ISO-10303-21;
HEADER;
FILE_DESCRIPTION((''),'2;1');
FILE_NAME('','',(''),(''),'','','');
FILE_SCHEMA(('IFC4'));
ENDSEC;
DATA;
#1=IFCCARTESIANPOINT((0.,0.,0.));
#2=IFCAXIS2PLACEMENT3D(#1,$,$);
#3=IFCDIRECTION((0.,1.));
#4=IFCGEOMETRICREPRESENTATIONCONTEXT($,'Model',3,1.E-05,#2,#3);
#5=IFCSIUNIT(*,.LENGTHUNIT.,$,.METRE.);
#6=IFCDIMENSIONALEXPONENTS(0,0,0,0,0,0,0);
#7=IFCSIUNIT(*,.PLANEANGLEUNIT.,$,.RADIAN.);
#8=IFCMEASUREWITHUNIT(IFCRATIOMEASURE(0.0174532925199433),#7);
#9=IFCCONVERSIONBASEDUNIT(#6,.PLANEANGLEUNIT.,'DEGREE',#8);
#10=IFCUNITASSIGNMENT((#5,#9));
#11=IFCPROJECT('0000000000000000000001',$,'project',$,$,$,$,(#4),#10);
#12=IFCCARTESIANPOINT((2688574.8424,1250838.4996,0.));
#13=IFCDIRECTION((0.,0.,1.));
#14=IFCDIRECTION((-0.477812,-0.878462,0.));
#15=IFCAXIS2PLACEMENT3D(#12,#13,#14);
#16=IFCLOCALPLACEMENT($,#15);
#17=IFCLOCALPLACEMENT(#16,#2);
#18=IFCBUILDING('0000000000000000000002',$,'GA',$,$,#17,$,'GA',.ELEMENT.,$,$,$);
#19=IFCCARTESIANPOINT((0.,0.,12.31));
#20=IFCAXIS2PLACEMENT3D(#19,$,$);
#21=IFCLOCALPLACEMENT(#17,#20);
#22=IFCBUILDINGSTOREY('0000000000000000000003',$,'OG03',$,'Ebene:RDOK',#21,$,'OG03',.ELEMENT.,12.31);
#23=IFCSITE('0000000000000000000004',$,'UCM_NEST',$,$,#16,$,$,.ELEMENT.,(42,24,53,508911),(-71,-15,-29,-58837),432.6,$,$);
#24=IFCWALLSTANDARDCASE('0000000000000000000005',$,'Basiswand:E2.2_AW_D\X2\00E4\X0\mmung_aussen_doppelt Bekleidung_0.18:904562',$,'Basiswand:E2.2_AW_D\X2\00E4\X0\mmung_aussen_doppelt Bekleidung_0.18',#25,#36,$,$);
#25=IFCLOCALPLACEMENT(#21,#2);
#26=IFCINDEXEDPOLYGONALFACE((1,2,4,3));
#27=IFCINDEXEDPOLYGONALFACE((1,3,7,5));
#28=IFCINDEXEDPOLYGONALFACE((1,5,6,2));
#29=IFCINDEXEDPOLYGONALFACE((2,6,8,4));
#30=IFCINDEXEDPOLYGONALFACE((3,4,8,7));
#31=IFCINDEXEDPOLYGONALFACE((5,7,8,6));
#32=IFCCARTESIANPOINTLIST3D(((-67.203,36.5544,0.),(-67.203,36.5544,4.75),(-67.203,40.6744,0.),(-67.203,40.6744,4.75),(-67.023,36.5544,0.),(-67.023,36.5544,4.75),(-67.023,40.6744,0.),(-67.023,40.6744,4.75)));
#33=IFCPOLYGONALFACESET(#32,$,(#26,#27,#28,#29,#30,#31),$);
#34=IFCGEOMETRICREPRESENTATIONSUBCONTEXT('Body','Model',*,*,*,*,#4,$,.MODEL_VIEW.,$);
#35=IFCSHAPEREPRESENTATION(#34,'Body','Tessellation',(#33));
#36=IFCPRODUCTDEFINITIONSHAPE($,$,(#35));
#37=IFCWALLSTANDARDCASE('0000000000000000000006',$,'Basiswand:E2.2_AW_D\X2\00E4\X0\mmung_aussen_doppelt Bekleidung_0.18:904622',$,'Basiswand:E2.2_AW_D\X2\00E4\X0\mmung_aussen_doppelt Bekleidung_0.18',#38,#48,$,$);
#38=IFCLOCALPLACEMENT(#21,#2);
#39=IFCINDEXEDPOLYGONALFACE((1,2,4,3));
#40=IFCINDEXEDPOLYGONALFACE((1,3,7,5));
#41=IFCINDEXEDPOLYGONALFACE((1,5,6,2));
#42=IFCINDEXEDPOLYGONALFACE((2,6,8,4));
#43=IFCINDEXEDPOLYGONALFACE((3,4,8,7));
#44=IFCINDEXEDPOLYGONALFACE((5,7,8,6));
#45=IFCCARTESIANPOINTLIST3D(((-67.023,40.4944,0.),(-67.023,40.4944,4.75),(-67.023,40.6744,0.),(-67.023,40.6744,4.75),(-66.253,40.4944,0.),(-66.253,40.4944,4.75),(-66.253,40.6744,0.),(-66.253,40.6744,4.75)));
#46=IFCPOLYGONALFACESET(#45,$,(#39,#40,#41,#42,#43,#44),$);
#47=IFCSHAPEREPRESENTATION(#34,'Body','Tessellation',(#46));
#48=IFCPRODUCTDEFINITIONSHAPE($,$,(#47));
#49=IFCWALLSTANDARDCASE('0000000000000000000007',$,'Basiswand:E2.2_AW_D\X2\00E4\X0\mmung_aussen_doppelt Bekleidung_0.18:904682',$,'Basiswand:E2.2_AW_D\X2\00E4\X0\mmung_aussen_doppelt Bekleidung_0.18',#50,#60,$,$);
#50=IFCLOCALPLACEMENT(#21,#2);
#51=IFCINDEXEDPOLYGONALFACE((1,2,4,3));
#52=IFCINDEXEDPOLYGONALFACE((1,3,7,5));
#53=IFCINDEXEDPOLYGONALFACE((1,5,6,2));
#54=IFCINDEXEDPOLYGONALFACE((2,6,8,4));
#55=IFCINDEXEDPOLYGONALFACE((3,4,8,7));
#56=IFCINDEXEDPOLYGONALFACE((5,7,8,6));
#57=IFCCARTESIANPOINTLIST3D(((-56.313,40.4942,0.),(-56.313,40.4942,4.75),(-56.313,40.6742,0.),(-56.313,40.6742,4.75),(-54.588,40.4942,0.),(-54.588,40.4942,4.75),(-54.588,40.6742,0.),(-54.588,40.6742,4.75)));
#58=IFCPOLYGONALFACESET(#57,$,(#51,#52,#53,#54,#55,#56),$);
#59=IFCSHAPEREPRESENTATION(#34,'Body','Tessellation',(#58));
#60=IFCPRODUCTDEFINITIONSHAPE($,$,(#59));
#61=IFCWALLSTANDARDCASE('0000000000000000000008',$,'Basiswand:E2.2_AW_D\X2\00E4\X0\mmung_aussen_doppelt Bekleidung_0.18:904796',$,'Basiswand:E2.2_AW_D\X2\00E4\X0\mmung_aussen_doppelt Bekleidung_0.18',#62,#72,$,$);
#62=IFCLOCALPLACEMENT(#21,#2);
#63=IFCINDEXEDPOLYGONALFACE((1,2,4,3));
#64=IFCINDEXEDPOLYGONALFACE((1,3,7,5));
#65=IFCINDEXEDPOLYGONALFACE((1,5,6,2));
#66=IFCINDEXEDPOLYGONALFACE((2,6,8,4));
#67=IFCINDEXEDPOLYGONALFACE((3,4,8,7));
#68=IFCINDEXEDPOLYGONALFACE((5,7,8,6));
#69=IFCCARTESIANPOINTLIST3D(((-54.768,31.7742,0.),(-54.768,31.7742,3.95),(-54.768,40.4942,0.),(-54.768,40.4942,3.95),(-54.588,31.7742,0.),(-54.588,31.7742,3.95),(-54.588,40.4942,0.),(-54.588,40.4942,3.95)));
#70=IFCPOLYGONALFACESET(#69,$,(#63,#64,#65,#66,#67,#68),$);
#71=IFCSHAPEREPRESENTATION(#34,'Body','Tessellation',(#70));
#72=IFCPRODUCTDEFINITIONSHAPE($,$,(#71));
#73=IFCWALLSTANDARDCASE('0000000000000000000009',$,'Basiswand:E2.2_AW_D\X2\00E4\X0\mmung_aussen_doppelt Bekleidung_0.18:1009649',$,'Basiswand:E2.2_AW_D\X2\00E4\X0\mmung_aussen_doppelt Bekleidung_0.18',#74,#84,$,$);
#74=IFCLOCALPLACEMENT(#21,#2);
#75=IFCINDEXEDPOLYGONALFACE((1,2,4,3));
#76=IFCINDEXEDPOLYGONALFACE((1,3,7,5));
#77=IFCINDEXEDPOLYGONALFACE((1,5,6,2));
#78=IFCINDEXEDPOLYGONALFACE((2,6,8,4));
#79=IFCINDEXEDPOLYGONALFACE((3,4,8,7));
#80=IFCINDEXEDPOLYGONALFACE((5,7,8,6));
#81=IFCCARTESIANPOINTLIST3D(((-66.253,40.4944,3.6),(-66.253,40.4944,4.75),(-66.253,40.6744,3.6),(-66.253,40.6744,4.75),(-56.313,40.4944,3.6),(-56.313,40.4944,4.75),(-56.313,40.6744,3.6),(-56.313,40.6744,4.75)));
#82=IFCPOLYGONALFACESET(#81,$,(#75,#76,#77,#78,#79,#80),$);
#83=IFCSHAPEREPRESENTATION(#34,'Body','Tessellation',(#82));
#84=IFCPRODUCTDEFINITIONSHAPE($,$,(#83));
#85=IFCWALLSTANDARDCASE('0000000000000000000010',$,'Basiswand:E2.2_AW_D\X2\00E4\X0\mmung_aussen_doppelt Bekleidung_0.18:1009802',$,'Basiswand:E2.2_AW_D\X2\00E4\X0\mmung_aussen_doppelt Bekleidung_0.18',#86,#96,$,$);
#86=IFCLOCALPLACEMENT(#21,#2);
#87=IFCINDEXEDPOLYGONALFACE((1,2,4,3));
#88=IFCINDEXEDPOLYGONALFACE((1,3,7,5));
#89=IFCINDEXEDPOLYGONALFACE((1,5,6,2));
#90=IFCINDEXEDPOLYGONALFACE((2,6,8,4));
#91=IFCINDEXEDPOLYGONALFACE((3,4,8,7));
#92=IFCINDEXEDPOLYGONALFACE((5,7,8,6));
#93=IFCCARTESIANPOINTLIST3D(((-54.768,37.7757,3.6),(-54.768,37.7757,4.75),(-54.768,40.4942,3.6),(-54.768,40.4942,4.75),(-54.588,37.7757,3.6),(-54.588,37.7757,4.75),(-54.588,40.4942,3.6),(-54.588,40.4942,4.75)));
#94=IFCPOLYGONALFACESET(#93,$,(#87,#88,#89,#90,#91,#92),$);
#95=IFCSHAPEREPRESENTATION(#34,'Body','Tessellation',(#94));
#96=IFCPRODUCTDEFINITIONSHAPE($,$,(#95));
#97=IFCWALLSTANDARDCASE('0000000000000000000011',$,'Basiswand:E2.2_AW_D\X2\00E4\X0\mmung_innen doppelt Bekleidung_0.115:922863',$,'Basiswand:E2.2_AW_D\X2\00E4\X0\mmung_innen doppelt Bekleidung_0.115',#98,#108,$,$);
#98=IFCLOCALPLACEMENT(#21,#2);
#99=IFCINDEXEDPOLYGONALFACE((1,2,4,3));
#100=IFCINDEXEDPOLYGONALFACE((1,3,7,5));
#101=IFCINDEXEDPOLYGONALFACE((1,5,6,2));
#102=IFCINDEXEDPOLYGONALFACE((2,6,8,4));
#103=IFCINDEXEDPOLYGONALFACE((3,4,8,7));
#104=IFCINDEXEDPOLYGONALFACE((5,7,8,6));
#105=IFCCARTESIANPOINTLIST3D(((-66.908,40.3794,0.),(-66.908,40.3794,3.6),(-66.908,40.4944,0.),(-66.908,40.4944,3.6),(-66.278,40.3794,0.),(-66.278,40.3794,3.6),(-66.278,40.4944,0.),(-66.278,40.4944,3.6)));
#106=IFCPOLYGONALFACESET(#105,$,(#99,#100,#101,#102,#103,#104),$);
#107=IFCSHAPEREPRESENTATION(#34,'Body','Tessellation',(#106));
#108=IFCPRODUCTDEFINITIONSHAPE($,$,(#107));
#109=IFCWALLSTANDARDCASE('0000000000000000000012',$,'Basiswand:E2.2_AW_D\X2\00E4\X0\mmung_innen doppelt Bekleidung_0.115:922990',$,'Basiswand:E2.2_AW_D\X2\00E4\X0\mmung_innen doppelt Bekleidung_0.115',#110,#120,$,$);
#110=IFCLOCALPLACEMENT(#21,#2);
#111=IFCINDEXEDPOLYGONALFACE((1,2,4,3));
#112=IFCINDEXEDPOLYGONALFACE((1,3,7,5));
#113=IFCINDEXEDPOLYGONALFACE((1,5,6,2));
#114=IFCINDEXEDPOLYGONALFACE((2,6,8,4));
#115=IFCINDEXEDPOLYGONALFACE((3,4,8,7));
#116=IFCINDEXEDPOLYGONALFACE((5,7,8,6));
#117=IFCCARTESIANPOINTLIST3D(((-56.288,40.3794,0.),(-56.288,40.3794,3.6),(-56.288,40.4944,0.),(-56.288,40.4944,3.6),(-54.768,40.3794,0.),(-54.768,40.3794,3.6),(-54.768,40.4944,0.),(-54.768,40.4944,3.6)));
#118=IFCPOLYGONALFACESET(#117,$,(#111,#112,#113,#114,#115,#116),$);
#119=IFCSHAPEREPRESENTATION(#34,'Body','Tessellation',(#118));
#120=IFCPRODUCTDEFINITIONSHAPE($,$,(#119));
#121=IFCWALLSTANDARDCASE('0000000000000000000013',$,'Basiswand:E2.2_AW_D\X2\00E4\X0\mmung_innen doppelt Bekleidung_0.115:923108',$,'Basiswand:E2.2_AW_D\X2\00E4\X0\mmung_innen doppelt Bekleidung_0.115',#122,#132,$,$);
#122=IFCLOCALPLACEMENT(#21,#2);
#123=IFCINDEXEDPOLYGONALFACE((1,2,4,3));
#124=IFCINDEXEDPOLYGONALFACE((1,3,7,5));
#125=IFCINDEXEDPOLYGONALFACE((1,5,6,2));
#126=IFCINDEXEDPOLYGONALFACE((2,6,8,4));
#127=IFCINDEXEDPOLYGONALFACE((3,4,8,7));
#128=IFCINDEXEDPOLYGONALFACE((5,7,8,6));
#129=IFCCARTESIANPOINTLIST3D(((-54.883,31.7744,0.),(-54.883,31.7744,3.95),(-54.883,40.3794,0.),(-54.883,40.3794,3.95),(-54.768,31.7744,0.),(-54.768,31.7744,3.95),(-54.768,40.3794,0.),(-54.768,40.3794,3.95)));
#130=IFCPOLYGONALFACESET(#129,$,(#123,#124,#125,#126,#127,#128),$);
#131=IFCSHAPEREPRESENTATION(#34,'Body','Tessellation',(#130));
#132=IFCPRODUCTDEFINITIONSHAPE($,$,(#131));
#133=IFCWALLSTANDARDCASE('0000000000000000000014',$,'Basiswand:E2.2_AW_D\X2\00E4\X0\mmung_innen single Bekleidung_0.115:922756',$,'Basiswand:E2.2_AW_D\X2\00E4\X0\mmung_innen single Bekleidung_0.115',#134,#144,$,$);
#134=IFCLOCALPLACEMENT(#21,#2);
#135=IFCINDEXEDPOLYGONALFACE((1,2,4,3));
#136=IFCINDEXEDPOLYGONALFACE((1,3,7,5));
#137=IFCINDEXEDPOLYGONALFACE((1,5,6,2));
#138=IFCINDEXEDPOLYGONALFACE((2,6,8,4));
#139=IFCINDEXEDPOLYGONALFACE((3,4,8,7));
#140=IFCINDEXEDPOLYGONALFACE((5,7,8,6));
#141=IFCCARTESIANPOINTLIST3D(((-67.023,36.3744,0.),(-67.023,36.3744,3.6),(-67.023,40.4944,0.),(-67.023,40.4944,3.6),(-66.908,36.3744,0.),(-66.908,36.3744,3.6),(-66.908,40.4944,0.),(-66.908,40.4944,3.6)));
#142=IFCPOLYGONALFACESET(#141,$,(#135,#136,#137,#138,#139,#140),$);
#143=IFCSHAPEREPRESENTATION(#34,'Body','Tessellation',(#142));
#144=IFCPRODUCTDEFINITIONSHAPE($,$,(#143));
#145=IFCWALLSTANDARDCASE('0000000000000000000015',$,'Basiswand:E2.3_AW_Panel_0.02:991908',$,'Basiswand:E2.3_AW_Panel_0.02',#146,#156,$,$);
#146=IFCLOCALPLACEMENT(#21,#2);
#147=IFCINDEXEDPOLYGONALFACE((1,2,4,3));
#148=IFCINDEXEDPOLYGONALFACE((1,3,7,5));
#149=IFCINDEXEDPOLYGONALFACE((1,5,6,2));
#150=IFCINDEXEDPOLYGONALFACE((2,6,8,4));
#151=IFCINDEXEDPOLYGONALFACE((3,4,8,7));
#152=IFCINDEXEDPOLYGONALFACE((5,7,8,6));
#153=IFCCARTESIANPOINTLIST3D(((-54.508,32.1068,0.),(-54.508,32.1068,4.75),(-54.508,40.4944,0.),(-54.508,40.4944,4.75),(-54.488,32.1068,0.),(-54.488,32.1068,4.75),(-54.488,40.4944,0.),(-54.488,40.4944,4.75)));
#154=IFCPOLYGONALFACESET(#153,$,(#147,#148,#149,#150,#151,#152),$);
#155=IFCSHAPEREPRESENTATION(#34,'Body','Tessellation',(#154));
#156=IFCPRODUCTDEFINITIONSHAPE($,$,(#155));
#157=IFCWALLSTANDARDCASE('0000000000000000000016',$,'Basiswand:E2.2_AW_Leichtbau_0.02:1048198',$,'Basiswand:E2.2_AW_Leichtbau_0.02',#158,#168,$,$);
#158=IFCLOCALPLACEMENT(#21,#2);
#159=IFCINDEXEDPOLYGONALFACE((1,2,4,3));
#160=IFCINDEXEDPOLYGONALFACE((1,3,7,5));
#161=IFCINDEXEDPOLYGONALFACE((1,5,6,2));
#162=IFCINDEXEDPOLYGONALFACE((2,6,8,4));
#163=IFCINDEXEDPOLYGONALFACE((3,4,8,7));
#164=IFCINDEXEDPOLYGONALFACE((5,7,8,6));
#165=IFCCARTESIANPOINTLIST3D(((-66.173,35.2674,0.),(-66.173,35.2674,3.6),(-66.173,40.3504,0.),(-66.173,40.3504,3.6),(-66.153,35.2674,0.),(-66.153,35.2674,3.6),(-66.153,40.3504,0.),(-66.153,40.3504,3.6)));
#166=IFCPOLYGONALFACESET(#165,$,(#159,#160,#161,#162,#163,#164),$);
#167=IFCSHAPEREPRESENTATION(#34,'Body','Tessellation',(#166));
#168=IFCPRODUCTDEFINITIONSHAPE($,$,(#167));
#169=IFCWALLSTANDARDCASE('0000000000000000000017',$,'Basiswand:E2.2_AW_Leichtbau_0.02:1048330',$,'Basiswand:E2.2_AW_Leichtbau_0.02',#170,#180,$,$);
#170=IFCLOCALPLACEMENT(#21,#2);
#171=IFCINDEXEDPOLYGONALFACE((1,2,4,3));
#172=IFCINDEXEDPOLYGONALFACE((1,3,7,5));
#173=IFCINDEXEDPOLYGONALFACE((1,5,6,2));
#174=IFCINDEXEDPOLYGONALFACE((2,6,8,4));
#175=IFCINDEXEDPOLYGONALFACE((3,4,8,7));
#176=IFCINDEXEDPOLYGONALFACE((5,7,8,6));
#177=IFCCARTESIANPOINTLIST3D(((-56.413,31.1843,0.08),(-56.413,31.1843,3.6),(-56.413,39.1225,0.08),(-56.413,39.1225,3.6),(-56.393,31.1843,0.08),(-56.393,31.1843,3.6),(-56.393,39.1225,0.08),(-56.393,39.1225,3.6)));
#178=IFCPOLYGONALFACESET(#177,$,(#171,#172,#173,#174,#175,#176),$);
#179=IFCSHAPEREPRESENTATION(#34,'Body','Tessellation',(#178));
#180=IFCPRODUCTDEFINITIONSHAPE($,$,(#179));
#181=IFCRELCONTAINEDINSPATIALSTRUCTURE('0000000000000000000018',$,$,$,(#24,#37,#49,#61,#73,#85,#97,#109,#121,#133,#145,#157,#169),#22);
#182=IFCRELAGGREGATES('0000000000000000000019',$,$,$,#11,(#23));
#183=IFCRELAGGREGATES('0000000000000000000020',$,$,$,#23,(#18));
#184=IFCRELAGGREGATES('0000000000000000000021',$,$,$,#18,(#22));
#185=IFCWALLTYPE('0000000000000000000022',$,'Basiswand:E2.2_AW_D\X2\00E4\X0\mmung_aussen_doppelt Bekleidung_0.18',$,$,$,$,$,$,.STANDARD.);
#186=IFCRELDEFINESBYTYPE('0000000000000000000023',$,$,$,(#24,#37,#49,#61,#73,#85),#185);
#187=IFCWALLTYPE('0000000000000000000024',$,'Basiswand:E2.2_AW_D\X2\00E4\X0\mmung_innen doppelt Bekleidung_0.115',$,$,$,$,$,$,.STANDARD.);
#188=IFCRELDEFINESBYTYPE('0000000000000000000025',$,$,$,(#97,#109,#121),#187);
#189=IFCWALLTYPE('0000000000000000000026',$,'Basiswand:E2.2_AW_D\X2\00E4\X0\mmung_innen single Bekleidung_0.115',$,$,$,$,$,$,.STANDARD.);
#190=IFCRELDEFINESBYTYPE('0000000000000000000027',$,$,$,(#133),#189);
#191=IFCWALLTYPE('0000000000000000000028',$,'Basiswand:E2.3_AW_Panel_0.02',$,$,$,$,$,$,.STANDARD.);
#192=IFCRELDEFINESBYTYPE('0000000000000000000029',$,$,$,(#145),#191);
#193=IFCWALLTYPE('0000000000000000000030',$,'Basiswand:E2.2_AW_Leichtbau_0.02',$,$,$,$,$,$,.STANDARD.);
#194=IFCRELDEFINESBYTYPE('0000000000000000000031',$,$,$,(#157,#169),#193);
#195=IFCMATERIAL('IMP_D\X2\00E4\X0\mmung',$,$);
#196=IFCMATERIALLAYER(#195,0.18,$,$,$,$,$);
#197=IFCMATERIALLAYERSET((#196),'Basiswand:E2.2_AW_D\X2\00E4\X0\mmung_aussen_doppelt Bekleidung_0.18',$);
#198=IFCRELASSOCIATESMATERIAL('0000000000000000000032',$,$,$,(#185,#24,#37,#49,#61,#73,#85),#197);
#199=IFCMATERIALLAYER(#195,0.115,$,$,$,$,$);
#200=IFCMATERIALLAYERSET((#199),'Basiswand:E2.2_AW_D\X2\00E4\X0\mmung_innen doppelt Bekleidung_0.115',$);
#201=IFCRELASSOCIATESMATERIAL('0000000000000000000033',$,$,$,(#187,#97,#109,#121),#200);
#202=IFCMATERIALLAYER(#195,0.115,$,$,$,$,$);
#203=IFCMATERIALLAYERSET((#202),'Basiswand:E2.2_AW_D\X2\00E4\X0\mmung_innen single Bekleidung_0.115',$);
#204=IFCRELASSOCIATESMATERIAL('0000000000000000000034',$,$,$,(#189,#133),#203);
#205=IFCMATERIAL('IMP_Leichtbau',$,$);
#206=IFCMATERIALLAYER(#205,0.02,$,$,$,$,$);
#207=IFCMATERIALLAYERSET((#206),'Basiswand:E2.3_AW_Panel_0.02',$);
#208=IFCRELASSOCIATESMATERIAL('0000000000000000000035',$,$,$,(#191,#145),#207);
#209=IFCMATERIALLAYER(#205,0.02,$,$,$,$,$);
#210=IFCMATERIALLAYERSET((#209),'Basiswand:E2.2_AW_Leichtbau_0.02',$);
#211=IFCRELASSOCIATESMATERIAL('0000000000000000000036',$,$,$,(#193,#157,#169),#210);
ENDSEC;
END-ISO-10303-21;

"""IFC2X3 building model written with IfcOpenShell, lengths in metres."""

from ifc_helpers import new_model, entity, si_unit, converted_unit, direction, frame, frame_2d, origin, place, context, subcontext, project, spatial, polyline, rectangle, extrude, clip, bounded_halfspace, material, layer, layer_set, layer_usage, type_object, element, save


model = new_model("IFC2X3")

# Units and contexts
model_context = context("Model", 3, precision=1e-05, world=origin(), true_north=direction((0.0, 1.0)))
body_context = subcontext(model_context, "Body", "Model", "MODEL_VIEW")
ifc_project = project(units=[si_unit("LENGTHUNIT", "METRE"), converted_unit("PLANEANGLEUNIT", "DEGREE", entity("IfcRatioMeasure", 0.0174532925199433), si_unit("PLANEANGLEUNIT", "RADIAN"), dimensions=[0, 0, 0, 0, 0, 0, 0])], contexts=[model_context])

# Site, building, storey
site_placement = place(None, frame((2688574.8424, 1250838.4996, 0.0), z_axis=(0.0, 0.0, 1.0), x_axis=(-0.477812, -0.878462, 0.0)))
site = spatial("IfcSite", under=ifc_project, at=site_placement, Name="UCM_NEST", CompositionType="ELEMENT", RefLatitude=(42, 24, 53, 508911), RefLongitude=(-71, -15, -29, -58837), RefElevation=432.6)
building_placement = place(site_placement, origin())
building = spatial("IfcBuilding", under=site, at=building_placement, Name="GA", LongName="GA", CompositionType="ELEMENT")
storey_placement = place(building_placement, frame((0.0, 0.0, 12.31)))
storey = spatial("IfcBuildingStorey", under=building, at=storey_placement, Name="OG03", ObjectType="Ebene:RDOK", LongName="OG03", CompositionType="ELEMENT", Elevation=12.31)

# Walls
ifc_material_1 = material(Name="IMP_Dämmung")
ifc_layer_1 = layer(ifc_material_1, 0.18)
ifc_layer_set_1 = layer_set([ifc_layer_1], Name="Basiswand:E2.2_AW_Dämmung_aussen_doppelt Bekleidung_0.18")
ifc_layer_usage_1 = layer_usage(ifc_layer_set_1, "AXIS2", "NEGATIVE", 0.09)
wall_type_1 = type_object("IfcWallType", Name="Basiswand:E2.2_AW_Dämmung_aussen_doppelt Bekleidung_0.18", PredefinedType="STANDARD", material=ifc_layer_set_1)
wall_1_placement = place(storey_placement, frame((-67.113, 36.5544, 0.0), z_axis=(0.0, 0.0, 1.0), x_axis=(0.0, 1.0, 0.0)))
element("IfcWallStandardCase", 1, at=wall_1_placement, inside=storey, type_object=wall_type_1, material=ifc_layer_usage_1, Name="Basiswand:E2.2_AW_Dämmung_aussen_doppelt Bekleidung_0.18:904562", ObjectType="Basiswand:E2.2_AW_Dämmung_aussen_doppelt Bekleidung_0.18", context=body_context, shape_type="SweptSolid", body=[
    extrude(rectangle(XDim=4.12, YDim=0.18, at=frame_2d((2.06, 0.0), x_axis=(-1.0, 0.0))), origin(), (0.0, 0.0, 1.0), 4.75),
])
ifc_layer_usage_2 = layer_usage(ifc_layer_set_1, "AXIS2", "NEGATIVE", 0.09)
wall_2_placement = place(storey_placement, frame((-67.023, 40.5844, 0.0)))
element("IfcWallStandardCase", 2, at=wall_2_placement, inside=storey, type_object=wall_type_1, material=ifc_layer_usage_2, Name="Basiswand:E2.2_AW_Dämmung_aussen_doppelt Bekleidung_0.18:904622", ObjectType="Basiswand:E2.2_AW_Dämmung_aussen_doppelt Bekleidung_0.18", context=body_context, shape_type="SweptSolid", body=[
    extrude(rectangle(XDim=0.77, YDim=0.18, at=frame_2d((0.385, 0.0), x_axis=(-1.0, 0.0))), origin(), (0.0, 0.0, 1.0), 4.75),
])
ifc_layer_usage_3 = layer_usage(ifc_layer_set_1, "AXIS2", "NEGATIVE", 0.09)
wall_3_placement = place(storey_placement, frame((-56.313, 40.5842, 0.0)))
element("IfcWallStandardCase", 3, at=wall_3_placement, inside=storey, type_object=wall_type_1, material=ifc_layer_usage_3, Name="Basiswand:E2.2_AW_Dämmung_aussen_doppelt Bekleidung_0.18:904682", ObjectType="Basiswand:E2.2_AW_Dämmung_aussen_doppelt Bekleidung_0.18", context=body_context, shape_type="SweptSolid", body=[
    extrude(rectangle(XDim=1.725, YDim=0.18, at=frame_2d((0.8625, 0.0), x_axis=(-1.0, 0.0))), origin(), (0.0, 0.0, 1.0), 4.75),
])
ifc_layer_usage_4 = layer_usage(ifc_layer_set_1, "AXIS2", "NEGATIVE", 0.09)
wall_4_placement = place(storey_placement, frame((-54.678, 40.4942, 0.0), z_axis=(0.0, 0.0, 1.0), x_axis=(0.0, -1.0, 0.0)))
element("IfcWallStandardCase", 4, at=wall_4_placement, inside=storey, type_object=wall_type_1, material=ifc_layer_usage_4, Name="Basiswand:E2.2_AW_Dämmung_aussen_doppelt Bekleidung_0.18:904796", ObjectType="Basiswand:E2.2_AW_Dämmung_aussen_doppelt Bekleidung_0.18", context=body_context, shape_type="SweptSolid", body=[
    extrude(rectangle(XDim=8.72, YDim=0.18, at=frame_2d((4.36, 0.0), x_axis=(-1.0, 0.0))), origin(), (0.0, 0.0, 1.0), 3.95),
])
ifc_layer_usage_5 = layer_usage(ifc_layer_set_1, "AXIS2", "NEGATIVE", 0.09)
wall_5_placement = place(storey_placement, frame((-66.253, 40.5844, 3.6)))
element("IfcWallStandardCase", 5, at=wall_5_placement, inside=storey, type_object=wall_type_1, material=ifc_layer_usage_5, Name="Basiswand:E2.2_AW_Dämmung_aussen_doppelt Bekleidung_0.18:1009649", ObjectType="Basiswand:E2.2_AW_Dämmung_aussen_doppelt Bekleidung_0.18", context=body_context, shape_type="SweptSolid", body=[
    extrude(rectangle(XDim=9.94, YDim=0.18, at=frame_2d((4.97, 0.0), x_axis=(-1.0, 0.0))), origin(), (0.0, 0.0, 1.0), 1.15),
])
ifc_layer_usage_6 = layer_usage(ifc_layer_set_1, "AXIS2", "NEGATIVE", 0.09)
wall_6_placement = place(storey_placement, frame((-54.678, 37.7757, 3.6), z_axis=(0.0, 0.0, 1.0), x_axis=(0.0, 1.0, 0.0)))
element("IfcWallStandardCase", 6, at=wall_6_placement, inside=storey, type_object=wall_type_1, material=ifc_layer_usage_6, Name="Basiswand:E2.2_AW_Dämmung_aussen_doppelt Bekleidung_0.18:1009802", ObjectType="Basiswand:E2.2_AW_Dämmung_aussen_doppelt Bekleidung_0.18", context=body_context, shape_type="SweptSolid", body=[
    extrude(rectangle(XDim=2.7185, YDim=0.18, at=frame_2d((1.3592, 0.0), x_axis=(-1.0, 0.0))), origin(), (0.0, 0.0, 1.0), 1.15),
])
ifc_layer_2 = layer(ifc_material_1, 0.115)
ifc_layer_set_2 = layer_set([ifc_layer_2], Name="Basiswand:E2.2_AW_Dämmung_innen doppelt Bekleidung_0.115")
ifc_layer_usage_7 = layer_usage(ifc_layer_set_2, "AXIS2", "NEGATIVE", 0.0575)
wall_type_2 = type_object("IfcWallType", Name="Basiswand:E2.2_AW_Dämmung_innen doppelt Bekleidung_0.115", PredefinedType="STANDARD", material=ifc_layer_set_2)
wall_7_placement = place(storey_placement, frame((-66.908, 40.4369, 0.0)))
element("IfcWallStandardCase", 7, at=wall_7_placement, inside=storey, type_object=wall_type_2, material=ifc_layer_usage_7, Name="Basiswand:E2.2_AW_Dämmung_innen doppelt Bekleidung_0.115:922863", ObjectType="Basiswand:E2.2_AW_Dämmung_innen doppelt Bekleidung_0.115", context=body_context, shape_type="SweptSolid", body=[
    extrude(rectangle(XDim=0.63, YDim=0.115, at=frame_2d((0.315, 0.0), x_axis=(-1.0, 0.0))), origin(), (0.0, 0.0, 1.0), 3.6),
])
ifc_layer_usage_8 = layer_usage(ifc_layer_set_2, "AXIS2", "NEGATIVE", 0.0575)
wall_8_placement = place(storey_placement, frame((-56.288, 40.4369, 0.0)))
element("IfcWallStandardCase", 8, at=wall_8_placement, inside=storey, type_object=wall_type_2, material=ifc_layer_usage_8, Name="Basiswand:E2.2_AW_Dämmung_innen doppelt Bekleidung_0.115:922990", ObjectType="Basiswand:E2.2_AW_Dämmung_innen doppelt Bekleidung_0.115", context=body_context, shape_type="SweptSolid", body=[
    extrude(rectangle(XDim=1.52, YDim=0.115, at=frame_2d((0.76, 0.0), x_axis=(-1.0, 0.0))), origin(), (0.0, 0.0, 1.0), 3.6),
])
ifc_layer_usage_9 = layer_usage(ifc_layer_set_2, "AXIS2", "NEGATIVE", 0.0575)
wall_9_placement = place(storey_placement, frame((-54.8255, 40.3794, 0.0), z_axis=(0.0, 0.0, 1.0), x_axis=(0.0, -1.0, 0.0)))
element("IfcWallStandardCase", 9, at=wall_9_placement, inside=storey, type_object=wall_type_2, material=ifc_layer_usage_9, Name="Basiswand:E2.2_AW_Dämmung_innen doppelt Bekleidung_0.115:923108", ObjectType="Basiswand:E2.2_AW_Dämmung_innen doppelt Bekleidung_0.115", context=body_context, shape_type="SweptSolid", body=[
    extrude(rectangle(XDim=8.605, YDim=0.115, at=frame_2d((4.3025, 0.0), x_axis=(-1.0, 0.0))), origin(), (0.0, 0.0, 1.0), 3.95),
])
ifc_layer_3 = layer(ifc_material_1, 0.115)
ifc_layer_set_3 = layer_set([ifc_layer_3], Name="Basiswand:E2.2_AW_Dämmung_innen single Bekleidung_0.115")
ifc_layer_usage_10 = layer_usage(ifc_layer_set_3, "AXIS2", "NEGATIVE", 0.0575)
wall_type_3 = type_object("IfcWallType", Name="Basiswand:E2.2_AW_Dämmung_innen single Bekleidung_0.115", PredefinedType="STANDARD", material=ifc_layer_set_3)
wall_10_placement = place(storey_placement, frame((-66.9655, 36.3744, 0.0), z_axis=(0.0, 0.0, 1.0), x_axis=(0.0, 1.0, 0.0)))
element("IfcWallStandardCase", 10, at=wall_10_placement, inside=storey, type_object=wall_type_3, material=ifc_layer_usage_10, Name="Basiswand:E2.2_AW_Dämmung_innen single Bekleidung_0.115:922756", ObjectType="Basiswand:E2.2_AW_Dämmung_innen single Bekleidung_0.115", context=body_context, shape_type="SweptSolid", body=[
    extrude(rectangle(XDim=4.12, YDim=0.115, at=frame_2d((2.06, 0.0), x_axis=(-1.0, 0.0))), origin(), (0.0, 0.0, 1.0), 3.6),
])

# Walls
ifc_material_2 = material(Name="IMP_Leichtbau")
ifc_layer_4 = layer(ifc_material_2, 0.02)
ifc_layer_set_4 = layer_set([ifc_layer_4], Name="Basiswand:E2.3_AW_Panel_0.02")
ifc_layer_usage_11 = layer_usage(ifc_layer_set_4, "AXIS2", "NEGATIVE", 0.01)
wall_type_4 = type_object("IfcWallType", Name="Basiswand:E2.3_AW_Panel_0.02", PredefinedType="STANDARD", material=ifc_layer_set_4)
wall_11_placement = place(storey_placement, frame((-54.498, 40.4944, 0.0), z_axis=(0.0, 0.0, 1.0), x_axis=(0.0, -1.0, 0.0)))
element("IfcWallStandardCase", 11, at=wall_11_placement, inside=storey, type_object=wall_type_4, material=ifc_layer_usage_11, Name="Basiswand:E2.3_AW_Panel_0.02:991908", ObjectType="Basiswand:E2.3_AW_Panel_0.02", context=body_context, shape_type="SweptSolid", body=[
    extrude(rectangle(XDim=8.3877, YDim=0.02, at=frame_2d((4.1938, 0.0), x_axis=(-1.0, 0.0))), origin(), (0.0, 0.0, 1.0), 4.75),
])
ifc_layer_5 = layer(ifc_material_2, 0.02)
ifc_layer_set_5 = layer_set([ifc_layer_5], Name="Basiswand:E2.2_AW_Leichtbau_0.02")
ifc_layer_usage_12 = layer_usage(ifc_layer_set_5, "AXIS2", "NEGATIVE", 0.01)
wall_type_5 = type_object("IfcWallType", Name="Basiswand:E2.2_AW_Leichtbau_0.02", PredefinedType="STANDARD", material=ifc_layer_set_5)
wall_12_placement = place(storey_placement, frame((-66.163, 35.2674, 0.0), z_axis=(0.0, 0.0, 1.0), x_axis=(0.0, 1.0, 0.0)))
element("IfcWallStandardCase", 12, at=wall_12_placement, inside=storey, type_object=wall_type_5, material=ifc_layer_usage_12, Name="Basiswand:E2.2_AW_Leichtbau_0.02:1048198", ObjectType="Basiswand:E2.2_AW_Leichtbau_0.02", context=body_context, shape_type="SweptSolid", body=[
    extrude(rectangle(XDim=5.083, YDim=0.02, at=frame_2d((2.5415, 0.0), x_axis=(-1.0, 0.0))), origin(), (0.0, 0.0, 1.0), 3.6),
])
ifc_layer_usage_13 = layer_usage(ifc_layer_set_5, "AXIS2", "NEGATIVE", 0.01)
wall_13_placement = place(storey_placement, frame((-56.403, 31.1843, 0.08), z_axis=(0.0, 0.0, 1.0), x_axis=(0.0, 1.0, 0.0)))
element("IfcWallStandardCase", 13, at=wall_13_placement, inside=storey, type_object=wall_type_5, material=ifc_layer_usage_13, Name="Basiswand:E2.2_AW_Leichtbau_0.02:1048330", ObjectType="Basiswand:E2.2_AW_Leichtbau_0.02", context=body_context, shape_type="Clipping", body=[
    clip(extrude(rectangle(XDim=7.9382, YDim=0.02, at=frame_2d((3.9691, 0.0), x_axis=(-1.0, 0.0))), origin(), (0.0, 0.0, 1.0), 3.52), bounded_halfspace(frame((7.9382, -0.01, 0.0), z_axis=(0.0, 0.0, 1.0), x_axis=(0.0, 1.0, 0.0)), True, frame((7.9382, -0.01, 0.0), z_axis=(0.0, 0.0, 1.0), x_axis=(0.0, 1.0, 0.0)), polyline([(0.0, 0.0), (0.02, 0.0), (0.02, 7.9382), (0.0, 7.9382), (0.0, 0.0)]))),
])

save(model, "model.ifc")
